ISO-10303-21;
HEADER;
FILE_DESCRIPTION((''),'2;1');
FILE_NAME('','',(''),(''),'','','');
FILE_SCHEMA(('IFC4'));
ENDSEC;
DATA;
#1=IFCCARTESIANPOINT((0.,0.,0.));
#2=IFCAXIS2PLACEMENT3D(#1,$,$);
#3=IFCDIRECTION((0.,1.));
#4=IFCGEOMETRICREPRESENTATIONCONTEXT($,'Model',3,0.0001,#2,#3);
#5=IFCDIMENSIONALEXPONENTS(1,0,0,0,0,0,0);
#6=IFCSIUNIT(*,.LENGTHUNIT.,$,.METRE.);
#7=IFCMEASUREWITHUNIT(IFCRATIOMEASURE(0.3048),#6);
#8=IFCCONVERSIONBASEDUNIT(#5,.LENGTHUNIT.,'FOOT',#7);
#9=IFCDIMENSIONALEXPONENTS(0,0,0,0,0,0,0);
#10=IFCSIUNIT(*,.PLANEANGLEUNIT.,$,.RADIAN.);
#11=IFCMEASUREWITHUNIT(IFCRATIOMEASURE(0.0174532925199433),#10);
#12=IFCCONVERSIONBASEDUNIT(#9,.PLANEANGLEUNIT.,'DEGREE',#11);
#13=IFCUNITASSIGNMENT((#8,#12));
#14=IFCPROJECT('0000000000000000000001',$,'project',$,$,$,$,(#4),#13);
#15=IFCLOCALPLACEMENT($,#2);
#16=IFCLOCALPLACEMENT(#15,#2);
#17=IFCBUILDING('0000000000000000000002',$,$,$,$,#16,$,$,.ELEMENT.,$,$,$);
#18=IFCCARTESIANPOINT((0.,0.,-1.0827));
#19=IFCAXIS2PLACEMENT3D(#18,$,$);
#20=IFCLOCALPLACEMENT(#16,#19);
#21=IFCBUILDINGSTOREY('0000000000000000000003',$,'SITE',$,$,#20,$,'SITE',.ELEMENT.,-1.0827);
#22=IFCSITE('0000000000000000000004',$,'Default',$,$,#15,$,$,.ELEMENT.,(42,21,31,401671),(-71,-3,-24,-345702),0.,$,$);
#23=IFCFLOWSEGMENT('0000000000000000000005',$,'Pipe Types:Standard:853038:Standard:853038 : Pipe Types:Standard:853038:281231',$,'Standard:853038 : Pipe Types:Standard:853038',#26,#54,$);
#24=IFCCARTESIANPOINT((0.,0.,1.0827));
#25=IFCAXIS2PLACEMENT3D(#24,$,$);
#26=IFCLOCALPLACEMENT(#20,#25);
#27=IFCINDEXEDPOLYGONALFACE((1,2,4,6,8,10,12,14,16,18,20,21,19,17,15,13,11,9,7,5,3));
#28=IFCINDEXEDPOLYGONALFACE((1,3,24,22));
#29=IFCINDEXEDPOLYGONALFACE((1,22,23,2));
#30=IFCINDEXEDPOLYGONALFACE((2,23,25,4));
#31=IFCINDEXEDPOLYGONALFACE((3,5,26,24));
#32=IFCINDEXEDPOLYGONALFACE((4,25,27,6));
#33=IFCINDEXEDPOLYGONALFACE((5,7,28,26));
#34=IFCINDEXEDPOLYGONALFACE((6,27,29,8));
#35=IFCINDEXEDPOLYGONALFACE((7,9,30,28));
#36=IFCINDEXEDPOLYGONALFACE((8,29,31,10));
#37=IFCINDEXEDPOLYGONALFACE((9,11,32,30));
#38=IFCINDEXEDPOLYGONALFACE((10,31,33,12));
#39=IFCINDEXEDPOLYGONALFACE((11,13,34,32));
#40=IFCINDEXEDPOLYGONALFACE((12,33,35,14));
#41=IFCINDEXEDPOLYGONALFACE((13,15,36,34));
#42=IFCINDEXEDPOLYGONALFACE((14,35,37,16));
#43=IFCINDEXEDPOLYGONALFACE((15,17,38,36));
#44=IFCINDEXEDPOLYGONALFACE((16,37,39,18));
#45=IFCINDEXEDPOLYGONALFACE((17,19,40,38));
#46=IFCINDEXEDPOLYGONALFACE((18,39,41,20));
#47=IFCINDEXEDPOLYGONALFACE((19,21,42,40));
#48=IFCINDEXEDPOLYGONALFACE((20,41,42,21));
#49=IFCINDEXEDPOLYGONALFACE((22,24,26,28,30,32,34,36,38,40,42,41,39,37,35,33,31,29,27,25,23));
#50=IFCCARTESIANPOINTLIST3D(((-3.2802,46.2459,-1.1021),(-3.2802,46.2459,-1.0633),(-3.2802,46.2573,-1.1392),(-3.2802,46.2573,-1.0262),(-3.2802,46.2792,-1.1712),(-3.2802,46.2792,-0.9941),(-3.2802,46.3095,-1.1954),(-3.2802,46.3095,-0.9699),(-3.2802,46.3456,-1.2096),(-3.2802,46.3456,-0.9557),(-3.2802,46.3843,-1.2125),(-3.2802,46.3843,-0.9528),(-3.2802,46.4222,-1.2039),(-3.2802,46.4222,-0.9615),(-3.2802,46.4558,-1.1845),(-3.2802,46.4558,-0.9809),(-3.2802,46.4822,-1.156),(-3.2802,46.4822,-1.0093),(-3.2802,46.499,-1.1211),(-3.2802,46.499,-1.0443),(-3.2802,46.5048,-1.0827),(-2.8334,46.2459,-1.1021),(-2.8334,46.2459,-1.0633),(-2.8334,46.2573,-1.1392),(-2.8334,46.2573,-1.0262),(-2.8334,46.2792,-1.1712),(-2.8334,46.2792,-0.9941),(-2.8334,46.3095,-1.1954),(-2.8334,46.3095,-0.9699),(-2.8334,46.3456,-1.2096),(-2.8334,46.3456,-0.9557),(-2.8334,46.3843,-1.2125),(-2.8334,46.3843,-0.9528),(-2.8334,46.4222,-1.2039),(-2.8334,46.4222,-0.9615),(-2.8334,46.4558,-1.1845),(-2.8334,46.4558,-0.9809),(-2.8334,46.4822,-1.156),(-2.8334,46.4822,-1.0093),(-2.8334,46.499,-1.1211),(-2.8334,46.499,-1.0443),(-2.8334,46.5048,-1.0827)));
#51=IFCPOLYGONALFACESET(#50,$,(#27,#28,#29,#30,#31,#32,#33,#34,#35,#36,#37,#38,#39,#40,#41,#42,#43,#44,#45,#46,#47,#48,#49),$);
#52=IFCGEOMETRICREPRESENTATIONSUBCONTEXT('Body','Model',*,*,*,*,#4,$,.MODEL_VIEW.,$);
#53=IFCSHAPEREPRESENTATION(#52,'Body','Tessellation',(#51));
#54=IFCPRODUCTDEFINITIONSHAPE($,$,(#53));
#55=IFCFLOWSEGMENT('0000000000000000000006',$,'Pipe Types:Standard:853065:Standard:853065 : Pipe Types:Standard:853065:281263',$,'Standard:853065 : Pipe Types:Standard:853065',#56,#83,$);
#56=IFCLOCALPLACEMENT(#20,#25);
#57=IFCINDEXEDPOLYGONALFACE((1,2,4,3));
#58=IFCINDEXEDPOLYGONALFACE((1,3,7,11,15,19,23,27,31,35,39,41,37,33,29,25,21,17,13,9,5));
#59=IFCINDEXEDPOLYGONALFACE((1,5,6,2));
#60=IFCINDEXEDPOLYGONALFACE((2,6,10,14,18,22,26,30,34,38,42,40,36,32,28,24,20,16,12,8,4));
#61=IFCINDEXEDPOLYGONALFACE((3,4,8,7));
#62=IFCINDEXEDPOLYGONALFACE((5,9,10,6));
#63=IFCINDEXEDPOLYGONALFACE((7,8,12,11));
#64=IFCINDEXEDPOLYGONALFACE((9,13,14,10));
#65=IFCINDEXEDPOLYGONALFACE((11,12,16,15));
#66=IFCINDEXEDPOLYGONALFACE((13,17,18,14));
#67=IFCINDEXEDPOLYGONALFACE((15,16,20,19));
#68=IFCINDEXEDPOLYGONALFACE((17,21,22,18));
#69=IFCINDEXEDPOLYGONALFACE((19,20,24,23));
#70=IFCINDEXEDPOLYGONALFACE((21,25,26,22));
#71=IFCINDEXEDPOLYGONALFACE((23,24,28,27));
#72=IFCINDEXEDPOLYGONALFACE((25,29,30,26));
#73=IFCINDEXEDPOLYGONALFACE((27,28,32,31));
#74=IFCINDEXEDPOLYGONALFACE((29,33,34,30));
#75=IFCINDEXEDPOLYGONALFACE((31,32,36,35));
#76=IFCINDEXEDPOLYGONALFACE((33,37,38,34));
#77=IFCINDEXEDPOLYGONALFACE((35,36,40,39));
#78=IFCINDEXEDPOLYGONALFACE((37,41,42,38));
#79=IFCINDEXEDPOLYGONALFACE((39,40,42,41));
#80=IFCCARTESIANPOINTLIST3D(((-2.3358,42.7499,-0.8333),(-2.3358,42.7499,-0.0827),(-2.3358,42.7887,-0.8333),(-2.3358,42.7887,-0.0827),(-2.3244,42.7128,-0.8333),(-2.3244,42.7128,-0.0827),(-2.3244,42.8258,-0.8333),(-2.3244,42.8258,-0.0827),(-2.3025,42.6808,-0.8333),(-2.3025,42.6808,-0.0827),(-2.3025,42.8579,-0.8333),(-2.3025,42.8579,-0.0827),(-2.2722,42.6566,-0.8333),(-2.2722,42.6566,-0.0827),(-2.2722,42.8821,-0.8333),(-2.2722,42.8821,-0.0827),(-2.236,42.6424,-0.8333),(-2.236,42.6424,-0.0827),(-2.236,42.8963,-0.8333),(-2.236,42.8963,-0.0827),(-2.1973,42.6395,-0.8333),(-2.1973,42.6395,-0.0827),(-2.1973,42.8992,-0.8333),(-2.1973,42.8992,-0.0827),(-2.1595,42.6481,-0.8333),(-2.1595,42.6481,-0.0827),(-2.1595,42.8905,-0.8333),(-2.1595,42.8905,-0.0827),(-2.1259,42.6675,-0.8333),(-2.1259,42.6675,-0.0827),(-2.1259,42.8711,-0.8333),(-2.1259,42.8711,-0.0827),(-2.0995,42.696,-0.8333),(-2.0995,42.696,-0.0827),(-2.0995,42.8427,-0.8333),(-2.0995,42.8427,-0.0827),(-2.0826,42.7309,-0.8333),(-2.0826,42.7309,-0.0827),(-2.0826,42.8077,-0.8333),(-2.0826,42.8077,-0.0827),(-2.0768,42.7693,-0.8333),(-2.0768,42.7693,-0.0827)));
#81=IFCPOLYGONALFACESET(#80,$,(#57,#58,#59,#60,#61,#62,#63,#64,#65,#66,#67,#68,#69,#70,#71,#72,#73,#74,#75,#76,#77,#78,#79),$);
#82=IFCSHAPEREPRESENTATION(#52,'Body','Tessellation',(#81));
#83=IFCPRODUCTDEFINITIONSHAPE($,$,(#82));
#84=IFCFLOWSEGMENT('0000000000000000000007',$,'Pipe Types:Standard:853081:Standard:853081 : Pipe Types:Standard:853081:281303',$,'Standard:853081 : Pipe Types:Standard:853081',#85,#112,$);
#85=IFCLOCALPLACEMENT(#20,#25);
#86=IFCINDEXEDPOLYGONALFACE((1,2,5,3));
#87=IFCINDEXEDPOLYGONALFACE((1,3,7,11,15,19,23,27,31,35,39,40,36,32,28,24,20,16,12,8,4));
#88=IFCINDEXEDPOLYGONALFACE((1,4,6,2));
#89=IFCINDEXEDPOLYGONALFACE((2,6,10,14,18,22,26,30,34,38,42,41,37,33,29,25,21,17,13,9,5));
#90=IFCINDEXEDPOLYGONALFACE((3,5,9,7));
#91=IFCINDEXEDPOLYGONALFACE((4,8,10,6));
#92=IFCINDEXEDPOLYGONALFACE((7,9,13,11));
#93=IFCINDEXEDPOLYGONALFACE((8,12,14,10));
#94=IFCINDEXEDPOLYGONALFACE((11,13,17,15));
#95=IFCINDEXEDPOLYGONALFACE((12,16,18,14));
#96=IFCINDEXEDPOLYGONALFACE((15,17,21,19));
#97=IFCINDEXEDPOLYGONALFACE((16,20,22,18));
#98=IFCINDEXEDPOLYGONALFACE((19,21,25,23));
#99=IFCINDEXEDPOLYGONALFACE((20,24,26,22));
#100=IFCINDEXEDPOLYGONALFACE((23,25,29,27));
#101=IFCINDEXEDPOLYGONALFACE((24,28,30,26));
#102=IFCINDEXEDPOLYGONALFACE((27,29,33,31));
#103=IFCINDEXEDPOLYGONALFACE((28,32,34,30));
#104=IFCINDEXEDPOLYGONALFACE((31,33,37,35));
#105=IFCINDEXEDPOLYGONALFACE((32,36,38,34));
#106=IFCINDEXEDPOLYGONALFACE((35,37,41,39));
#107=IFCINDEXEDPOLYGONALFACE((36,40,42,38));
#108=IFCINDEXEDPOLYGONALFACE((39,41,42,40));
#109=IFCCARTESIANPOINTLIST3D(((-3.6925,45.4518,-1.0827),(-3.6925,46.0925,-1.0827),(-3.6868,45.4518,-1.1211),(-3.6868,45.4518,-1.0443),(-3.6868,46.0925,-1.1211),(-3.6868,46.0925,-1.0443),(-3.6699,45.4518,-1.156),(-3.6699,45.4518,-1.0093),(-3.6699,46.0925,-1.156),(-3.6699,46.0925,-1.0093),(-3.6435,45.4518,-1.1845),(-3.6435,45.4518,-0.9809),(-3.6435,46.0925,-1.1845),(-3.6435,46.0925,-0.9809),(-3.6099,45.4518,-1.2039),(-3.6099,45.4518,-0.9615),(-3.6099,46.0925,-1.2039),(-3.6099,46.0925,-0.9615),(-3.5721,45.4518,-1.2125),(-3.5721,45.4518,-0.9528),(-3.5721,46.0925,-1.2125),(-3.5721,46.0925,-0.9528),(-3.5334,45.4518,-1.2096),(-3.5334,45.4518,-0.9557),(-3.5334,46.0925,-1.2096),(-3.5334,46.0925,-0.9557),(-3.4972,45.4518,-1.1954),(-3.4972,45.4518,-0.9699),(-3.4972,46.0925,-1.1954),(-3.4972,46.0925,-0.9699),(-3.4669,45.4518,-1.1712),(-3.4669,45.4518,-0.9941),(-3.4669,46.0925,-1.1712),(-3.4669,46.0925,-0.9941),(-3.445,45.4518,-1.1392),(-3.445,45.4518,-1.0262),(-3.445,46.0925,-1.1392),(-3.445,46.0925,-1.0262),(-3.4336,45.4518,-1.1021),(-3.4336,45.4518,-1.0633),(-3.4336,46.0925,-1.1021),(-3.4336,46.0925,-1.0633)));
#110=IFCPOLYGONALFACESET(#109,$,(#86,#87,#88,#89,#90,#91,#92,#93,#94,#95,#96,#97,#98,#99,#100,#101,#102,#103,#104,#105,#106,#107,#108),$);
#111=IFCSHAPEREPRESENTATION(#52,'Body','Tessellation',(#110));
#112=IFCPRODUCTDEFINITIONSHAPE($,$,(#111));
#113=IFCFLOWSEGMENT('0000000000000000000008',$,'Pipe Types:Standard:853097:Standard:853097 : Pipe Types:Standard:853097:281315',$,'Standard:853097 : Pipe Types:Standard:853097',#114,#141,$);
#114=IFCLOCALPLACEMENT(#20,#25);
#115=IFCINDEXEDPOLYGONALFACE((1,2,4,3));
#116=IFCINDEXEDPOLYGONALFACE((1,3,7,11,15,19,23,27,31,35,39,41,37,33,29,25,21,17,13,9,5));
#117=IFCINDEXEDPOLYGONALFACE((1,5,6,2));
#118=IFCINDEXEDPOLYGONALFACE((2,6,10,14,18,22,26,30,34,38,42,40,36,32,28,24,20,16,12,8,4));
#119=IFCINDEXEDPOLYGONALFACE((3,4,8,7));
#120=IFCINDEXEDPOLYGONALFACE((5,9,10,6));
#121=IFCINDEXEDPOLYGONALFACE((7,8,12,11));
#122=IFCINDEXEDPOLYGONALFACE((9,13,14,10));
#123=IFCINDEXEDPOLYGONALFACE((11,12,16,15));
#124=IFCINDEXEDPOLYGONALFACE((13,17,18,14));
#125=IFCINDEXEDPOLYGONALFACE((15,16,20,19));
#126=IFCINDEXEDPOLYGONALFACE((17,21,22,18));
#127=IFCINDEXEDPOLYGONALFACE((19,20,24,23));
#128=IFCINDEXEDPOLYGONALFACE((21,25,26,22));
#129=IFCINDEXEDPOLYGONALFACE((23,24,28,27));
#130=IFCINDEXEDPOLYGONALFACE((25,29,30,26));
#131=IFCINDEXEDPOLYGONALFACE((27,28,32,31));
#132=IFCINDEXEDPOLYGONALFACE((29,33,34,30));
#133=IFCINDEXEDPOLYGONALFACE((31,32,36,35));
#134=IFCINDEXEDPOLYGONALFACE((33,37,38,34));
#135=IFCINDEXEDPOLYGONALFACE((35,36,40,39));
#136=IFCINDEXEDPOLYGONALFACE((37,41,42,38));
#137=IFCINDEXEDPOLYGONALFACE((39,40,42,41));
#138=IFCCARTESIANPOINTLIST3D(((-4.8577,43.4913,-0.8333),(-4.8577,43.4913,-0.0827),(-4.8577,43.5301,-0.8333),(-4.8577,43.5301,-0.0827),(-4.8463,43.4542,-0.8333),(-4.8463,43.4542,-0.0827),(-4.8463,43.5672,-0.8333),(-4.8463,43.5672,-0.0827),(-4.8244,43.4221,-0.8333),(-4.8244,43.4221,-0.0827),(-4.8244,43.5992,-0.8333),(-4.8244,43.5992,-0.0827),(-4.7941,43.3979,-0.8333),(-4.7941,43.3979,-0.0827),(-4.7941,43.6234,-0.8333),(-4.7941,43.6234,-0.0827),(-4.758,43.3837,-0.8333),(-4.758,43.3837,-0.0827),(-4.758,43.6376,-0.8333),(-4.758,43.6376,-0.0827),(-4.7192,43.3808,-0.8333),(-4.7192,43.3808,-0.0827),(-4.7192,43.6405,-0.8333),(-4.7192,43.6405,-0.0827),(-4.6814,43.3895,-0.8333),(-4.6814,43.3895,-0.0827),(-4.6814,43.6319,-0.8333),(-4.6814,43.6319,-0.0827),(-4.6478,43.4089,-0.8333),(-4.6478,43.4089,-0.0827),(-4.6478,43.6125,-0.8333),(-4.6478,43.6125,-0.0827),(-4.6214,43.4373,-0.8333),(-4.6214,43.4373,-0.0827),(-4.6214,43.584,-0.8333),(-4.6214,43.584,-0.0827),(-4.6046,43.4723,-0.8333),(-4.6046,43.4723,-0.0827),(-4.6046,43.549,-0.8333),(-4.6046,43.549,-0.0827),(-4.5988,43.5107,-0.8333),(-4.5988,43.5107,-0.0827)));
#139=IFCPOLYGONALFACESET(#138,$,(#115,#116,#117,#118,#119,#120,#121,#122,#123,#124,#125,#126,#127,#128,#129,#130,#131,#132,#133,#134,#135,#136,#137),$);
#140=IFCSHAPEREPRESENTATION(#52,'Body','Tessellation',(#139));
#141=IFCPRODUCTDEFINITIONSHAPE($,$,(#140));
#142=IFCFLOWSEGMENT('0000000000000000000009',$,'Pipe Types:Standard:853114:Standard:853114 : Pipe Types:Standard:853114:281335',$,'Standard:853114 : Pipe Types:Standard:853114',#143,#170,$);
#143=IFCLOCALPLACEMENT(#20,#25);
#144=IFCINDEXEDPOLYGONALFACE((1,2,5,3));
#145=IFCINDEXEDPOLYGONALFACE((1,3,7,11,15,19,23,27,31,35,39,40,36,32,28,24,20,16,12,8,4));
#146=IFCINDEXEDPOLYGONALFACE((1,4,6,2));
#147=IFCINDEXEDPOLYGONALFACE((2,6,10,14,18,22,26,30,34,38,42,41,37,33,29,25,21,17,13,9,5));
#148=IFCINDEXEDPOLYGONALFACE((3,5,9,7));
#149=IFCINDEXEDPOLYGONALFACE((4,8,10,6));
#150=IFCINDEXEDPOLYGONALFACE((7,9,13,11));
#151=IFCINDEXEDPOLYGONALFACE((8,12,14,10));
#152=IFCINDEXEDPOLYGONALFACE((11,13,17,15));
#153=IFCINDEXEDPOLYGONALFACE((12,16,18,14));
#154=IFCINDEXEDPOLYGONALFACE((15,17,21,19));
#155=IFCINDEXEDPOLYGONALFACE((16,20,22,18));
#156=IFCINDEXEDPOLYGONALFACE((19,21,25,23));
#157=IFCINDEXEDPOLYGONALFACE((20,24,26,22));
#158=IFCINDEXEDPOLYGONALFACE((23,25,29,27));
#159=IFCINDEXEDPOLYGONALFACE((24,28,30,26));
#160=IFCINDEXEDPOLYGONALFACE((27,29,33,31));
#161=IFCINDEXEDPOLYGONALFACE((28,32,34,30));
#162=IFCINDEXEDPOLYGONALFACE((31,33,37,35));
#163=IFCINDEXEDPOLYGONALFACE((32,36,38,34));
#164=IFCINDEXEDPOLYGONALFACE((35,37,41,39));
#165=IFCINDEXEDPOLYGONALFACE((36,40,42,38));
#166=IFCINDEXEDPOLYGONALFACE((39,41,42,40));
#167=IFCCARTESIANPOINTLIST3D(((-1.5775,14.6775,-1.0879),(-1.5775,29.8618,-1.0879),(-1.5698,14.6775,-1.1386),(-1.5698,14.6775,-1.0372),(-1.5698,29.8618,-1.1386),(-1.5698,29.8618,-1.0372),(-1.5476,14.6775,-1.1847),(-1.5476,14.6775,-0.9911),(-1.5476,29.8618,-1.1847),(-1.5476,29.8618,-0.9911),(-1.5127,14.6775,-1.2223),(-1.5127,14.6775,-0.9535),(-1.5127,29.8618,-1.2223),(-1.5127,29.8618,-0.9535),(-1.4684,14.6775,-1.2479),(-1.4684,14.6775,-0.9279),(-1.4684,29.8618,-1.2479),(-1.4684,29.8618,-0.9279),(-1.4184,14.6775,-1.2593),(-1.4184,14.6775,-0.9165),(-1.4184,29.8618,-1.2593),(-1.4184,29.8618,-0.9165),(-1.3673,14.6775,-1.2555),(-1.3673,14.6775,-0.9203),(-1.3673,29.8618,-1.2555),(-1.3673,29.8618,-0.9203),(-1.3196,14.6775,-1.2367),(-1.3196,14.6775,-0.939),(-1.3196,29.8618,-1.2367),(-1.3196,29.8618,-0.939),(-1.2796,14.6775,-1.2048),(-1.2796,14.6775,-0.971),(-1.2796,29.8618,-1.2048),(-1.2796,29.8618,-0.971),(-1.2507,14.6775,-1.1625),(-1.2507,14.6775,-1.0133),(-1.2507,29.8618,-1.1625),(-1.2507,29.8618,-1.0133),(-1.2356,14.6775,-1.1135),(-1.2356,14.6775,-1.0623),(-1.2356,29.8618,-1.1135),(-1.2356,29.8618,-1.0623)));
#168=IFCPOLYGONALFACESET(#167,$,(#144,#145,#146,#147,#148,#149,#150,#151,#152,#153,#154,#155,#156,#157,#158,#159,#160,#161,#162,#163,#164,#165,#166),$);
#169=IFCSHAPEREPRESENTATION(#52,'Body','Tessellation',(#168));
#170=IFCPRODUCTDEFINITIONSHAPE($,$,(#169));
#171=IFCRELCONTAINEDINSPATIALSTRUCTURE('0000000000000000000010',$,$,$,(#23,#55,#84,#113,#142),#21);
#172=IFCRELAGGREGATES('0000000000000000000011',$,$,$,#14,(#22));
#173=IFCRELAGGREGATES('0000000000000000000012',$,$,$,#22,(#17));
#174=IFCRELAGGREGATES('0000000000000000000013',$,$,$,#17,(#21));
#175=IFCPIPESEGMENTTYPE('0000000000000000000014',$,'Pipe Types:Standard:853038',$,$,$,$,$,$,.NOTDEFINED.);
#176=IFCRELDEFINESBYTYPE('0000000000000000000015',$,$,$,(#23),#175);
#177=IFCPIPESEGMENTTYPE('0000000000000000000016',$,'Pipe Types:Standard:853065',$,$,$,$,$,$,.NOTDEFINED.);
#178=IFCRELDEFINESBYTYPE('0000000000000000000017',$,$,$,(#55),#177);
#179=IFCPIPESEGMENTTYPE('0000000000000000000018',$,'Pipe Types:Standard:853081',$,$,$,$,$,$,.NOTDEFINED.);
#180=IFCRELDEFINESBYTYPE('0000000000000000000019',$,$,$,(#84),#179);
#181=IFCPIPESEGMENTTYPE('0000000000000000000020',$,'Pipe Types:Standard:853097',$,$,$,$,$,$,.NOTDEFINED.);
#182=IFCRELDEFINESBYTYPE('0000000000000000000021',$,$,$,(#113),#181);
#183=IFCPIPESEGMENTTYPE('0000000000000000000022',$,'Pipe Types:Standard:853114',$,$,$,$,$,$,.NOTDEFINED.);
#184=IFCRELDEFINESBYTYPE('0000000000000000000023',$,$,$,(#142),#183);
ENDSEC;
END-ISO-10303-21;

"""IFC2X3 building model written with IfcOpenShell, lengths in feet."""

from ifc_helpers import new_model, entity, si_unit, converted_unit, direction, frame, frame_2d, origin, origin_2d_with_axis, place, context, subcontext, project, spatial, circle, extrude, source, transform, mapped, type_object, type_shapes, element, save


model = new_model("IFC2X3")

# Units and contexts
model_context = context("Model", 3, precision=0.0001, world=origin(), true_north=direction((0.0, 1.0)))
body_context = subcontext(model_context, "Body", "Model", "MODEL_VIEW")
ifc_project = project(units=[converted_unit("LENGTHUNIT", "FOOT", entity("IfcRatioMeasure", 0.3048), si_unit("LENGTHUNIT", "METRE"), dimensions=[1, 0, 0, 0, 0, 0, 0]), converted_unit("PLANEANGLEUNIT", "DEGREE", entity("IfcRatioMeasure", 0.0174532925199433), si_unit("PLANEANGLEUNIT", "RADIAN"), dimensions=[0, 0, 0, 0, 0, 0, 0])], contexts=[model_context])

# Site, building, storey
site_placement = place(None, origin())
site = spatial("IfcSite", under=ifc_project, at=site_placement, Name="Default", CompositionType="ELEMENT", RefLatitude=(42, 21, 31, 401671), RefLongitude=(-71, -3, -24, -345702), RefElevation=0.0)
building_placement = place(site_placement, origin())
building = spatial("IfcBuilding", under=site, at=building_placement, CompositionType="ELEMENT")
storey_placement = place(building_placement, frame((0.0, 0.0, -1.0827)))
storey = spatial("IfcBuildingStorey", under=building, at=storey_placement, Name="SITE", LongName="SITE", CompositionType="ELEMENT", Elevation=-1.0827)

# Flow segments
pipe_segment_type_1 = type_object("IfcPipeSegmentType", Name="Pipe Types:Standard:853038", PredefinedType="NOTDEFINED")
shared_shape_1 = source(origin(), body_context, "Body", "SweptSolid", [
    extrude(circle(Radius=0.1302, at=frame_2d((0.0, 0.0), x_axis=(1.0, 0.0))), frame((-3.2802, 46.3746, -1.0827), z_axis=(1.0, 0.0, 0.0), x_axis=(0.0, 1.0, 0.0)), (0.0, 0.0, 1.0), 0.4467),
])
type_shapes(pipe_segment_type_1, [shared_shape_1])
flow_segment_1_placement = place(storey_placement, frame((0.0, 0.0, 1.0827)))
element("IfcFlowSegment", 1, at=flow_segment_1_placement, inside=storey, type_object=pipe_segment_type_1, Name="Pipe Types:Standard:853038:Standard:853038 : Pipe Types:Standard:853038:281231", ObjectType="Standard:853038 : Pipe Types:Standard:853038", context=body_context, shape_type="MappedRepresentation", body=[
    mapped(shared_shape_1, transform((0.0, 0.0, 0.0), scale=1.0)),
])
pipe_segment_type_2 = type_object("IfcPipeSegmentType", Name="Pipe Types:Standard:853065", PredefinedType="NOTDEFINED")
shared_shape_2 = source(origin(), body_context, "Body", "SweptSolid", [
    extrude(circle(Radius=0.1302, at=origin_2d_with_axis()), frame((-2.2071, 42.7693, -0.8333)), (0.0, 0.0, 1.0), 0.7507),
])
type_shapes(pipe_segment_type_2, [shared_shape_2])
flow_segment_2_placement = place(storey_placement, frame((0.0, 0.0, 1.0827)))
element("IfcFlowSegment", 2, at=flow_segment_2_placement, inside=storey, type_object=pipe_segment_type_2, Name="Pipe Types:Standard:853065:Standard:853065 : Pipe Types:Standard:853065:281263", ObjectType="Standard:853065 : Pipe Types:Standard:853065", context=body_context, shape_type="MappedRepresentation", body=[
    mapped(shared_shape_2, transform((0.0, 0.0, 0.0), scale=1.0)),
])
pipe_segment_type_3 = type_object("IfcPipeSegmentType", Name="Pipe Types:Standard:853081", PredefinedType="NOTDEFINED")
shared_shape_3 = source(origin(), body_context, "Body", "SweptSolid", [
    extrude(circle(Radius=0.1302, at=frame_2d((0.0, 0.0), x_axis=(1.0, 0.0))), frame((-3.5623, 45.4518, -1.0827), z_axis=(0.0, 1.0, 0.0), x_axis=(-1.0, 0.0, 0.0)), (0.0, 0.0, 1.0), 0.6406),
])
type_shapes(pipe_segment_type_3, [shared_shape_3])
flow_segment_3_placement = place(storey_placement, frame((0.0, 0.0, 1.0827)))
element("IfcFlowSegment", 3, at=flow_segment_3_placement, inside=storey, type_object=pipe_segment_type_3, Name="Pipe Types:Standard:853081:Standard:853081 : Pipe Types:Standard:853081:281303", ObjectType="Standard:853081 : Pipe Types:Standard:853081", context=body_context, shape_type="MappedRepresentation", body=[
    mapped(shared_shape_3, transform((0.0, 0.0, 0.0), scale=1.0)),
])
pipe_segment_type_4 = type_object("IfcPipeSegmentType", Name="Pipe Types:Standard:853097", PredefinedType="NOTDEFINED")
shared_shape_4 = source(origin(), body_context, "Body", "SweptSolid", [
    extrude(circle(Radius=0.1302, at=origin_2d_with_axis()), frame((-4.729, 43.5107, -0.8333)), (0.0, 0.0, 1.0), 0.7507),
])
type_shapes(pipe_segment_type_4, [shared_shape_4])
flow_segment_4_placement = place(storey_placement, frame((0.0, 0.0, 1.0827)))
element("IfcFlowSegment", 4, at=flow_segment_4_placement, inside=storey, type_object=pipe_segment_type_4, Name="Pipe Types:Standard:853097:Standard:853097 : Pipe Types:Standard:853097:281315", ObjectType="Standard:853097 : Pipe Types:Standard:853097", context=body_context, shape_type="MappedRepresentation", body=[
    mapped(shared_shape_4, transform((0.0, 0.0, 0.0), scale=1.0)),
])
pipe_segment_type_5 = type_object("IfcPipeSegmentType", Name="Pipe Types:Standard:853114", PredefinedType="NOTDEFINED")
shared_shape_5 = source(origin(), body_context, "Body", "SweptSolid", [
    extrude(circle(Radius=0.1719, at=frame_2d((0.0, 0.0), x_axis=(1.0, 0.0))), frame((-1.4056, 14.6775, -1.0879), z_axis=(0.0, 1.0, 0.0), x_axis=(-1.0, 0.0, 0.0)), (0.0, 0.0, 1.0), 15.1844),
])
type_shapes(pipe_segment_type_5, [shared_shape_5])
flow_segment_5_placement = place(storey_placement, frame((0.0, 0.0, 1.0827)))
element("IfcFlowSegment", 5, at=flow_segment_5_placement, inside=storey, type_object=pipe_segment_type_5, Name="Pipe Types:Standard:853114:Standard:853114 : Pipe Types:Standard:853114:281335", ObjectType="Standard:853114 : Pipe Types:Standard:853114", context=body_context, shape_type="MappedRepresentation", body=[
    mapped(shared_shape_5, transform((0.0, 0.0, 0.0), scale=1.0)),
])

save(model, "model.ifc")
